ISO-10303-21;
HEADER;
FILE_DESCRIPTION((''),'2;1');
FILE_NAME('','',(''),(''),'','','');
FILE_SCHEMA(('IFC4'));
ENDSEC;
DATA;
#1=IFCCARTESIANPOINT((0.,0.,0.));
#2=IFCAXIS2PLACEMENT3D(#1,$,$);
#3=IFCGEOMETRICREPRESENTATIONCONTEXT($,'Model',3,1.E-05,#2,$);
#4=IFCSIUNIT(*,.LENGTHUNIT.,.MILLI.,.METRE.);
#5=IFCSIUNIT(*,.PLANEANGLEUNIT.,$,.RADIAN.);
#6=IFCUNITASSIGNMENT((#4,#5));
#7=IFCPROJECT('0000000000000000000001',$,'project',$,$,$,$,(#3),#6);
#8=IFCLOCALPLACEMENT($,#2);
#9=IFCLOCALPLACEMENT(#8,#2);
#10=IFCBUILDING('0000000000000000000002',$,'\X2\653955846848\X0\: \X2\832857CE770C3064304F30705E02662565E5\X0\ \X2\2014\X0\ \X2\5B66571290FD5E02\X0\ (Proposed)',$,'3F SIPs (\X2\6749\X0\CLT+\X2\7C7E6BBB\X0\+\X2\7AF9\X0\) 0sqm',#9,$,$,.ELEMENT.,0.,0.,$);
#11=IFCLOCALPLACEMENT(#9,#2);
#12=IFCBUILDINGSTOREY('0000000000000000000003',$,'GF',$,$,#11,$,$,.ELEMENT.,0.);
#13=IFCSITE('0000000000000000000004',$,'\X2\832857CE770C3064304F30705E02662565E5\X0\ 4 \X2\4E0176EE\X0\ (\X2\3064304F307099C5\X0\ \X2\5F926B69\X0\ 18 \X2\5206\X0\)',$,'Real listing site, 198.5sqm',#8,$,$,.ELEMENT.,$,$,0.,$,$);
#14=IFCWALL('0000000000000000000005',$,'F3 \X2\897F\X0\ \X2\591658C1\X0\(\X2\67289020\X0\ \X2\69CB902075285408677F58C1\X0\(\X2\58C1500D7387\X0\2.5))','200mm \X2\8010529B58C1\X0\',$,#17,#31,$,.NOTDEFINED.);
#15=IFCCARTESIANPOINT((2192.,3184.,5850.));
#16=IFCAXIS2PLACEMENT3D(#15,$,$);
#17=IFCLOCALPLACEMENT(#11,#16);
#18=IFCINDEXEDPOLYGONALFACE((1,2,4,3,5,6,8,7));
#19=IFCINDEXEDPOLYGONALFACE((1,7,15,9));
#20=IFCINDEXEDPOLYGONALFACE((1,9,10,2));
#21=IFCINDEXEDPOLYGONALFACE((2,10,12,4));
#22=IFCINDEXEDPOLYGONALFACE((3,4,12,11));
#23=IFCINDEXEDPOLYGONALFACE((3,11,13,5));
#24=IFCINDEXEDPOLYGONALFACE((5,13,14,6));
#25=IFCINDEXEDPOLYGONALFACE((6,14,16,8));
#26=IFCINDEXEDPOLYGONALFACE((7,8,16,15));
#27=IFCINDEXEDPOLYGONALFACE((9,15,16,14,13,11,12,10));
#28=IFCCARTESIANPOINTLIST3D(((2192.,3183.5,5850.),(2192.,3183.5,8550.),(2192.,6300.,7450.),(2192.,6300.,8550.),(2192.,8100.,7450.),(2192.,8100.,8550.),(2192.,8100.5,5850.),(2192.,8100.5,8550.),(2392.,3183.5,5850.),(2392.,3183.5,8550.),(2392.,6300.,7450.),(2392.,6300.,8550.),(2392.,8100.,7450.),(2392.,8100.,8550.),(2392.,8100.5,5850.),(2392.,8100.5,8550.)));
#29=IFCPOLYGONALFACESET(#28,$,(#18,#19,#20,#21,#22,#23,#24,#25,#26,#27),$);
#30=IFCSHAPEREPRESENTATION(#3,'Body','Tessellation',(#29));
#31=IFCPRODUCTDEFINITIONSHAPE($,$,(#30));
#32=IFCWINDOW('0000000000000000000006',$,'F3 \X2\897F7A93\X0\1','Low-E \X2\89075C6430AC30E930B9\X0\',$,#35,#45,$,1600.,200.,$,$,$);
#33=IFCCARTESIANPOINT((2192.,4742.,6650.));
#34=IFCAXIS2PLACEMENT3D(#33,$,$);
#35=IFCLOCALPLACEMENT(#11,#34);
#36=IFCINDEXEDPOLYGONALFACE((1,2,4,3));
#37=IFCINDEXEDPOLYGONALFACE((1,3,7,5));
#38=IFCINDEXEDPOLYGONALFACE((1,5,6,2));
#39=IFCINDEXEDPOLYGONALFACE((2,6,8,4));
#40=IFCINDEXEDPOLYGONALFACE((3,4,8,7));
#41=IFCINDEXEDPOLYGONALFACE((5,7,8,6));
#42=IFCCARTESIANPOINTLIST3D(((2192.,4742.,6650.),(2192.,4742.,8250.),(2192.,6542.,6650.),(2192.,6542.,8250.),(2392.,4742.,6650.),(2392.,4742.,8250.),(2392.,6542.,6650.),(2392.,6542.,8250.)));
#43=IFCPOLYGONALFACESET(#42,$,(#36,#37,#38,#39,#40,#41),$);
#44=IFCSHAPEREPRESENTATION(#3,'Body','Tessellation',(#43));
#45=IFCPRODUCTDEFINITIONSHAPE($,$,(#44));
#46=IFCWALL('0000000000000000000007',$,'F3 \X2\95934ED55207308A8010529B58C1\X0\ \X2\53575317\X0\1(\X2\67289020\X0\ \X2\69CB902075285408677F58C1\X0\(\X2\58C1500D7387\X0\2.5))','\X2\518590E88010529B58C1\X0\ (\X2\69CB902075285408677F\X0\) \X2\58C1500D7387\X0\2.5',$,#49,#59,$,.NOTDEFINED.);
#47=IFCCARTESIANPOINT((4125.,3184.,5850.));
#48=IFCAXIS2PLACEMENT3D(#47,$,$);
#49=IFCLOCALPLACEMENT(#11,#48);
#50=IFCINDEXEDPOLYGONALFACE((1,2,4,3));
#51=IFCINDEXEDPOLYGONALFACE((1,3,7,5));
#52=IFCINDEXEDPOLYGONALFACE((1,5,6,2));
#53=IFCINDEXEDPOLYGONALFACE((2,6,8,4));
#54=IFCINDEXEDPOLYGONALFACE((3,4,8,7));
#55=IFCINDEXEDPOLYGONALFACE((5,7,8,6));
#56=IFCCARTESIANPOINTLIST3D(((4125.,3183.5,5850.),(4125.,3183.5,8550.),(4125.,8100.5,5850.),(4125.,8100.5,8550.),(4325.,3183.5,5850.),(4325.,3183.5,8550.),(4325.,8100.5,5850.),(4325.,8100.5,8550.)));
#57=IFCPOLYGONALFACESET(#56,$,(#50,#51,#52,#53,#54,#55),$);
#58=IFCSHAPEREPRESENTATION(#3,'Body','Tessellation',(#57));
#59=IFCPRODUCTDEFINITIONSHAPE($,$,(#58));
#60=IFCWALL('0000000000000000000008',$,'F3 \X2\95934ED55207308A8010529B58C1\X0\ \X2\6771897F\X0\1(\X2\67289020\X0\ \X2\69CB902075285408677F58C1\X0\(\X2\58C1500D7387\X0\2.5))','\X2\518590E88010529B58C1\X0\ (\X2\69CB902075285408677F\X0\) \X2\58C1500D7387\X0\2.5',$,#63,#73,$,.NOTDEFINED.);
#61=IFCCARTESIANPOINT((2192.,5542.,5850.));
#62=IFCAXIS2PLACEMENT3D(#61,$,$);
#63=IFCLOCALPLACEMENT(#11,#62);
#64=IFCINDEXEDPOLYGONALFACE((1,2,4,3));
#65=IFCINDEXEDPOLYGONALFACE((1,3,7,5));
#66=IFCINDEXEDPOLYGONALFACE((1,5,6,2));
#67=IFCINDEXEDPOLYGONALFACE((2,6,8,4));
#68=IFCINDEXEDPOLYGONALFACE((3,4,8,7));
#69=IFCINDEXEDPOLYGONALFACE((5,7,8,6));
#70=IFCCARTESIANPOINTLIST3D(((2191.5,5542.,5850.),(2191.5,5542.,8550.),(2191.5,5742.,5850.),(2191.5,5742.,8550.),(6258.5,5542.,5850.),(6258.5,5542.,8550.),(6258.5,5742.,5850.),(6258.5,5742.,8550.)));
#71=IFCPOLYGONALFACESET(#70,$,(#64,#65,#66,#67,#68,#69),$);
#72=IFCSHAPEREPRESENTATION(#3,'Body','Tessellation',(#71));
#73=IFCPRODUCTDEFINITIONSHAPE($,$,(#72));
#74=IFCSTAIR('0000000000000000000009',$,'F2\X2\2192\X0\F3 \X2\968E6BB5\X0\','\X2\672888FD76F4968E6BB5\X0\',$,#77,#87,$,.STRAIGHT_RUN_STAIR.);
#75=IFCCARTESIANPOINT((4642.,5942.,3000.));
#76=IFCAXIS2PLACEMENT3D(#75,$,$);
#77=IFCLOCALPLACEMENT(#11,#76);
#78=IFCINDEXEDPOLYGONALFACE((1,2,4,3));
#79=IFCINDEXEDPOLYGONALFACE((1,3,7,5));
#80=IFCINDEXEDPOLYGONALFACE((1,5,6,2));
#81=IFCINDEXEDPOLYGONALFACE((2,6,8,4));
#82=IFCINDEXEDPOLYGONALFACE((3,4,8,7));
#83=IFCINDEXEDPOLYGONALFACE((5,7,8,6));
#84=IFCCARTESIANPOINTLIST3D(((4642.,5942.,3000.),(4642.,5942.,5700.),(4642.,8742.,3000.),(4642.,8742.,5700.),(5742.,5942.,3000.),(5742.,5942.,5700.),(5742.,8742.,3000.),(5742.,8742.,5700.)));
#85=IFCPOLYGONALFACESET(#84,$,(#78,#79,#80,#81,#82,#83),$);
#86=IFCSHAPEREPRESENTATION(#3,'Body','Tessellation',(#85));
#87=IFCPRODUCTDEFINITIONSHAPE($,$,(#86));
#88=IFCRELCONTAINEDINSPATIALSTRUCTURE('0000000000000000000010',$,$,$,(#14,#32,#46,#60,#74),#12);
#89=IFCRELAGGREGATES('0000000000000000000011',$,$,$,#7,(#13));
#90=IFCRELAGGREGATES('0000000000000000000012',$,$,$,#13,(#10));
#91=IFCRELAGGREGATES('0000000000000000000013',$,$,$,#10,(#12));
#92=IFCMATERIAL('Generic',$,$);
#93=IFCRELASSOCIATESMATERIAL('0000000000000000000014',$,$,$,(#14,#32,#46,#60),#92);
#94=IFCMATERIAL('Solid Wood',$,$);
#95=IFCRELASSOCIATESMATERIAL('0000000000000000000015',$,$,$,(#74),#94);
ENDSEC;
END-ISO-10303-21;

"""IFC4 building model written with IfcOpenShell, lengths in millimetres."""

from ifc_helpers import new_model, si_unit, frame, frame_2d, origin, place, context, project, spatial, rectangle, extrude, material, element, fill, save


model = new_model("IFC4")

# Units and contexts
model_context = context("Model", 3, precision=1e-05, world=origin())
ifc_project = project(units=[si_unit("LENGTHUNIT", "METRE", prefix="MILLI"), si_unit("PLANEANGLEUNIT", "RADIAN")], contexts=[model_context])

# Site, building, storey
site_placement = place(None, origin())
site = spatial("IfcSite", under=ifc_project, at=site_placement, Name="茨城県つくば市春日 4 丁目 (つくば駅 徒歩 18 分)", ObjectType="Real listing site, 198.5sqm", CompositionType="ELEMENT", RefElevation=0.0)
building_placement = place(site_placement, origin())
building = spatial("IfcBuilding", under=site, at=building_placement, Name="改善案: 茨城県つくば市春日 — 学園都市 (Proposed)", ObjectType="3F SIPs (杉CLT+籾殻+竹) 0sqm", CompositionType="ELEMENT", ElevationOfRefHeight=0.0, ElevationOfTerrain=0.0)
storey_placement = place(building_placement, origin())
storey = spatial("IfcBuildingStorey", under=building, at=storey_placement, Name="GF", CompositionType="ELEMENT", Elevation=0.0)

# Shared definitions
ifc_material_1 = material(Name="Generic")

# Wall, opening, window
wall_1_placement = place(storey_placement, frame((2192.0, 3184.0, 5850.0)))
wall_1 = element("IfcWall", 1, at=wall_1_placement, inside=storey, material=ifc_material_1, Name="F3 西 外壁(木造 構造用合板壁(壁倍率2.5))", Description="200mm 耐力壁", PredefinedType="NOTDEFINED", context=model_context, shape_type="SweptSolid", body=[
    extrude(rectangle(XDim=200.0, YDim=4917.0, at=frame_2d((100.0, 2458.0))), frame((2192.0, 3184.0, 5850.0)), (0.0, 0.0, 1.0), 2700.0),
])
opening_1_placement = place(storey_placement, frame((2192.0, 4742.0, 6650.0)))
opening_1 = element("IfcOpeningElement", 2, at=opening_1_placement, cuts=wall_1, PredefinedType="NOTDEFINED", context=model_context, shape_type="SweptSolid", body=[
    extrude(rectangle(XDim=200.0, YDim=1800.0, at=frame_2d((100.0, 900.0))), frame((2192.0, 4742.0, 6650.0)), (0.0, 0.0, 1.0), 1600.0),
])
window_1_placement = place(storey_placement, frame((2192.0, 4742.0, 6650.0)))
window_1 = element("IfcWindow", 3, at=window_1_placement, inside=storey, material=ifc_material_1, Name="F3 西窓1", Description="Low-E 複層ガラス", OverallHeight=1600.0, OverallWidth=200.0, context=model_context, shape_type="SweptSolid", body=[
    extrude(rectangle(XDim=200.0, YDim=1800.0, at=frame_2d((100.0, 900.0))), frame((2192.0, 4742.0, 6650.0)), (0.0, 0.0, 1.0), 1600.0),
])
fill(opening_1, window_1)

# Walls
wall_2_placement = place(storey_placement, frame((4125.0, 3184.0, 5850.0)))
element("IfcWall", 4, at=wall_2_placement, inside=storey, material=ifc_material_1, Name="F3 間仕切り耐力壁 南北1(木造 構造用合板壁(壁倍率2.5))", Description="内部耐力壁 (構造用合板) 壁倍率2.5", PredefinedType="NOTDEFINED", context=model_context, shape_type="SweptSolid", body=[
    extrude(rectangle(XDim=200.0, YDim=4917.0, at=frame_2d((100.0, 2458.0))), frame((4125.0, 3184.0, 5850.0)), (0.0, 0.0, 1.0), 2700.0),
])
wall_3_placement = place(storey_placement, frame((2192.0, 5542.0, 5850.0)))
element("IfcWall", 5, at=wall_3_placement, inside=storey, material=ifc_material_1, Name="F3 間仕切り耐力壁 東西1(木造 構造用合板壁(壁倍率2.5))", Description="内部耐力壁 (構造用合板) 壁倍率2.5", PredefinedType="NOTDEFINED", context=model_context, shape_type="SweptSolid", body=[
    extrude(rectangle(XDim=4067.0, YDim=200.0, at=frame_2d((2033.0, 100.0))), frame((2192.0, 5542.0, 5850.0)), (0.0, 0.0, 1.0), 2700.0),
])

# Stair
ifc_material_2 = material(Name="Solid Wood")
stair_placement = place(storey_placement, frame((4642.0, 5942.0, 3000.0)))
element("IfcStair", 6, at=stair_placement, inside=storey, material=ifc_material_2, Name="F2→F3 階段", Description="木製直階段", PredefinedType="STRAIGHT_RUN_STAIR", context=model_context, shape_type="SweptSolid", body=[
    extrude(rectangle(XDim=1100.0, YDim=2800.0, at=frame_2d((550.0, 1400.0))), frame((4642.0, 5942.0, 3000.0)), (0.0, 0.0, 1.0), 2700.0),
])

save(model, "model.ifc")
